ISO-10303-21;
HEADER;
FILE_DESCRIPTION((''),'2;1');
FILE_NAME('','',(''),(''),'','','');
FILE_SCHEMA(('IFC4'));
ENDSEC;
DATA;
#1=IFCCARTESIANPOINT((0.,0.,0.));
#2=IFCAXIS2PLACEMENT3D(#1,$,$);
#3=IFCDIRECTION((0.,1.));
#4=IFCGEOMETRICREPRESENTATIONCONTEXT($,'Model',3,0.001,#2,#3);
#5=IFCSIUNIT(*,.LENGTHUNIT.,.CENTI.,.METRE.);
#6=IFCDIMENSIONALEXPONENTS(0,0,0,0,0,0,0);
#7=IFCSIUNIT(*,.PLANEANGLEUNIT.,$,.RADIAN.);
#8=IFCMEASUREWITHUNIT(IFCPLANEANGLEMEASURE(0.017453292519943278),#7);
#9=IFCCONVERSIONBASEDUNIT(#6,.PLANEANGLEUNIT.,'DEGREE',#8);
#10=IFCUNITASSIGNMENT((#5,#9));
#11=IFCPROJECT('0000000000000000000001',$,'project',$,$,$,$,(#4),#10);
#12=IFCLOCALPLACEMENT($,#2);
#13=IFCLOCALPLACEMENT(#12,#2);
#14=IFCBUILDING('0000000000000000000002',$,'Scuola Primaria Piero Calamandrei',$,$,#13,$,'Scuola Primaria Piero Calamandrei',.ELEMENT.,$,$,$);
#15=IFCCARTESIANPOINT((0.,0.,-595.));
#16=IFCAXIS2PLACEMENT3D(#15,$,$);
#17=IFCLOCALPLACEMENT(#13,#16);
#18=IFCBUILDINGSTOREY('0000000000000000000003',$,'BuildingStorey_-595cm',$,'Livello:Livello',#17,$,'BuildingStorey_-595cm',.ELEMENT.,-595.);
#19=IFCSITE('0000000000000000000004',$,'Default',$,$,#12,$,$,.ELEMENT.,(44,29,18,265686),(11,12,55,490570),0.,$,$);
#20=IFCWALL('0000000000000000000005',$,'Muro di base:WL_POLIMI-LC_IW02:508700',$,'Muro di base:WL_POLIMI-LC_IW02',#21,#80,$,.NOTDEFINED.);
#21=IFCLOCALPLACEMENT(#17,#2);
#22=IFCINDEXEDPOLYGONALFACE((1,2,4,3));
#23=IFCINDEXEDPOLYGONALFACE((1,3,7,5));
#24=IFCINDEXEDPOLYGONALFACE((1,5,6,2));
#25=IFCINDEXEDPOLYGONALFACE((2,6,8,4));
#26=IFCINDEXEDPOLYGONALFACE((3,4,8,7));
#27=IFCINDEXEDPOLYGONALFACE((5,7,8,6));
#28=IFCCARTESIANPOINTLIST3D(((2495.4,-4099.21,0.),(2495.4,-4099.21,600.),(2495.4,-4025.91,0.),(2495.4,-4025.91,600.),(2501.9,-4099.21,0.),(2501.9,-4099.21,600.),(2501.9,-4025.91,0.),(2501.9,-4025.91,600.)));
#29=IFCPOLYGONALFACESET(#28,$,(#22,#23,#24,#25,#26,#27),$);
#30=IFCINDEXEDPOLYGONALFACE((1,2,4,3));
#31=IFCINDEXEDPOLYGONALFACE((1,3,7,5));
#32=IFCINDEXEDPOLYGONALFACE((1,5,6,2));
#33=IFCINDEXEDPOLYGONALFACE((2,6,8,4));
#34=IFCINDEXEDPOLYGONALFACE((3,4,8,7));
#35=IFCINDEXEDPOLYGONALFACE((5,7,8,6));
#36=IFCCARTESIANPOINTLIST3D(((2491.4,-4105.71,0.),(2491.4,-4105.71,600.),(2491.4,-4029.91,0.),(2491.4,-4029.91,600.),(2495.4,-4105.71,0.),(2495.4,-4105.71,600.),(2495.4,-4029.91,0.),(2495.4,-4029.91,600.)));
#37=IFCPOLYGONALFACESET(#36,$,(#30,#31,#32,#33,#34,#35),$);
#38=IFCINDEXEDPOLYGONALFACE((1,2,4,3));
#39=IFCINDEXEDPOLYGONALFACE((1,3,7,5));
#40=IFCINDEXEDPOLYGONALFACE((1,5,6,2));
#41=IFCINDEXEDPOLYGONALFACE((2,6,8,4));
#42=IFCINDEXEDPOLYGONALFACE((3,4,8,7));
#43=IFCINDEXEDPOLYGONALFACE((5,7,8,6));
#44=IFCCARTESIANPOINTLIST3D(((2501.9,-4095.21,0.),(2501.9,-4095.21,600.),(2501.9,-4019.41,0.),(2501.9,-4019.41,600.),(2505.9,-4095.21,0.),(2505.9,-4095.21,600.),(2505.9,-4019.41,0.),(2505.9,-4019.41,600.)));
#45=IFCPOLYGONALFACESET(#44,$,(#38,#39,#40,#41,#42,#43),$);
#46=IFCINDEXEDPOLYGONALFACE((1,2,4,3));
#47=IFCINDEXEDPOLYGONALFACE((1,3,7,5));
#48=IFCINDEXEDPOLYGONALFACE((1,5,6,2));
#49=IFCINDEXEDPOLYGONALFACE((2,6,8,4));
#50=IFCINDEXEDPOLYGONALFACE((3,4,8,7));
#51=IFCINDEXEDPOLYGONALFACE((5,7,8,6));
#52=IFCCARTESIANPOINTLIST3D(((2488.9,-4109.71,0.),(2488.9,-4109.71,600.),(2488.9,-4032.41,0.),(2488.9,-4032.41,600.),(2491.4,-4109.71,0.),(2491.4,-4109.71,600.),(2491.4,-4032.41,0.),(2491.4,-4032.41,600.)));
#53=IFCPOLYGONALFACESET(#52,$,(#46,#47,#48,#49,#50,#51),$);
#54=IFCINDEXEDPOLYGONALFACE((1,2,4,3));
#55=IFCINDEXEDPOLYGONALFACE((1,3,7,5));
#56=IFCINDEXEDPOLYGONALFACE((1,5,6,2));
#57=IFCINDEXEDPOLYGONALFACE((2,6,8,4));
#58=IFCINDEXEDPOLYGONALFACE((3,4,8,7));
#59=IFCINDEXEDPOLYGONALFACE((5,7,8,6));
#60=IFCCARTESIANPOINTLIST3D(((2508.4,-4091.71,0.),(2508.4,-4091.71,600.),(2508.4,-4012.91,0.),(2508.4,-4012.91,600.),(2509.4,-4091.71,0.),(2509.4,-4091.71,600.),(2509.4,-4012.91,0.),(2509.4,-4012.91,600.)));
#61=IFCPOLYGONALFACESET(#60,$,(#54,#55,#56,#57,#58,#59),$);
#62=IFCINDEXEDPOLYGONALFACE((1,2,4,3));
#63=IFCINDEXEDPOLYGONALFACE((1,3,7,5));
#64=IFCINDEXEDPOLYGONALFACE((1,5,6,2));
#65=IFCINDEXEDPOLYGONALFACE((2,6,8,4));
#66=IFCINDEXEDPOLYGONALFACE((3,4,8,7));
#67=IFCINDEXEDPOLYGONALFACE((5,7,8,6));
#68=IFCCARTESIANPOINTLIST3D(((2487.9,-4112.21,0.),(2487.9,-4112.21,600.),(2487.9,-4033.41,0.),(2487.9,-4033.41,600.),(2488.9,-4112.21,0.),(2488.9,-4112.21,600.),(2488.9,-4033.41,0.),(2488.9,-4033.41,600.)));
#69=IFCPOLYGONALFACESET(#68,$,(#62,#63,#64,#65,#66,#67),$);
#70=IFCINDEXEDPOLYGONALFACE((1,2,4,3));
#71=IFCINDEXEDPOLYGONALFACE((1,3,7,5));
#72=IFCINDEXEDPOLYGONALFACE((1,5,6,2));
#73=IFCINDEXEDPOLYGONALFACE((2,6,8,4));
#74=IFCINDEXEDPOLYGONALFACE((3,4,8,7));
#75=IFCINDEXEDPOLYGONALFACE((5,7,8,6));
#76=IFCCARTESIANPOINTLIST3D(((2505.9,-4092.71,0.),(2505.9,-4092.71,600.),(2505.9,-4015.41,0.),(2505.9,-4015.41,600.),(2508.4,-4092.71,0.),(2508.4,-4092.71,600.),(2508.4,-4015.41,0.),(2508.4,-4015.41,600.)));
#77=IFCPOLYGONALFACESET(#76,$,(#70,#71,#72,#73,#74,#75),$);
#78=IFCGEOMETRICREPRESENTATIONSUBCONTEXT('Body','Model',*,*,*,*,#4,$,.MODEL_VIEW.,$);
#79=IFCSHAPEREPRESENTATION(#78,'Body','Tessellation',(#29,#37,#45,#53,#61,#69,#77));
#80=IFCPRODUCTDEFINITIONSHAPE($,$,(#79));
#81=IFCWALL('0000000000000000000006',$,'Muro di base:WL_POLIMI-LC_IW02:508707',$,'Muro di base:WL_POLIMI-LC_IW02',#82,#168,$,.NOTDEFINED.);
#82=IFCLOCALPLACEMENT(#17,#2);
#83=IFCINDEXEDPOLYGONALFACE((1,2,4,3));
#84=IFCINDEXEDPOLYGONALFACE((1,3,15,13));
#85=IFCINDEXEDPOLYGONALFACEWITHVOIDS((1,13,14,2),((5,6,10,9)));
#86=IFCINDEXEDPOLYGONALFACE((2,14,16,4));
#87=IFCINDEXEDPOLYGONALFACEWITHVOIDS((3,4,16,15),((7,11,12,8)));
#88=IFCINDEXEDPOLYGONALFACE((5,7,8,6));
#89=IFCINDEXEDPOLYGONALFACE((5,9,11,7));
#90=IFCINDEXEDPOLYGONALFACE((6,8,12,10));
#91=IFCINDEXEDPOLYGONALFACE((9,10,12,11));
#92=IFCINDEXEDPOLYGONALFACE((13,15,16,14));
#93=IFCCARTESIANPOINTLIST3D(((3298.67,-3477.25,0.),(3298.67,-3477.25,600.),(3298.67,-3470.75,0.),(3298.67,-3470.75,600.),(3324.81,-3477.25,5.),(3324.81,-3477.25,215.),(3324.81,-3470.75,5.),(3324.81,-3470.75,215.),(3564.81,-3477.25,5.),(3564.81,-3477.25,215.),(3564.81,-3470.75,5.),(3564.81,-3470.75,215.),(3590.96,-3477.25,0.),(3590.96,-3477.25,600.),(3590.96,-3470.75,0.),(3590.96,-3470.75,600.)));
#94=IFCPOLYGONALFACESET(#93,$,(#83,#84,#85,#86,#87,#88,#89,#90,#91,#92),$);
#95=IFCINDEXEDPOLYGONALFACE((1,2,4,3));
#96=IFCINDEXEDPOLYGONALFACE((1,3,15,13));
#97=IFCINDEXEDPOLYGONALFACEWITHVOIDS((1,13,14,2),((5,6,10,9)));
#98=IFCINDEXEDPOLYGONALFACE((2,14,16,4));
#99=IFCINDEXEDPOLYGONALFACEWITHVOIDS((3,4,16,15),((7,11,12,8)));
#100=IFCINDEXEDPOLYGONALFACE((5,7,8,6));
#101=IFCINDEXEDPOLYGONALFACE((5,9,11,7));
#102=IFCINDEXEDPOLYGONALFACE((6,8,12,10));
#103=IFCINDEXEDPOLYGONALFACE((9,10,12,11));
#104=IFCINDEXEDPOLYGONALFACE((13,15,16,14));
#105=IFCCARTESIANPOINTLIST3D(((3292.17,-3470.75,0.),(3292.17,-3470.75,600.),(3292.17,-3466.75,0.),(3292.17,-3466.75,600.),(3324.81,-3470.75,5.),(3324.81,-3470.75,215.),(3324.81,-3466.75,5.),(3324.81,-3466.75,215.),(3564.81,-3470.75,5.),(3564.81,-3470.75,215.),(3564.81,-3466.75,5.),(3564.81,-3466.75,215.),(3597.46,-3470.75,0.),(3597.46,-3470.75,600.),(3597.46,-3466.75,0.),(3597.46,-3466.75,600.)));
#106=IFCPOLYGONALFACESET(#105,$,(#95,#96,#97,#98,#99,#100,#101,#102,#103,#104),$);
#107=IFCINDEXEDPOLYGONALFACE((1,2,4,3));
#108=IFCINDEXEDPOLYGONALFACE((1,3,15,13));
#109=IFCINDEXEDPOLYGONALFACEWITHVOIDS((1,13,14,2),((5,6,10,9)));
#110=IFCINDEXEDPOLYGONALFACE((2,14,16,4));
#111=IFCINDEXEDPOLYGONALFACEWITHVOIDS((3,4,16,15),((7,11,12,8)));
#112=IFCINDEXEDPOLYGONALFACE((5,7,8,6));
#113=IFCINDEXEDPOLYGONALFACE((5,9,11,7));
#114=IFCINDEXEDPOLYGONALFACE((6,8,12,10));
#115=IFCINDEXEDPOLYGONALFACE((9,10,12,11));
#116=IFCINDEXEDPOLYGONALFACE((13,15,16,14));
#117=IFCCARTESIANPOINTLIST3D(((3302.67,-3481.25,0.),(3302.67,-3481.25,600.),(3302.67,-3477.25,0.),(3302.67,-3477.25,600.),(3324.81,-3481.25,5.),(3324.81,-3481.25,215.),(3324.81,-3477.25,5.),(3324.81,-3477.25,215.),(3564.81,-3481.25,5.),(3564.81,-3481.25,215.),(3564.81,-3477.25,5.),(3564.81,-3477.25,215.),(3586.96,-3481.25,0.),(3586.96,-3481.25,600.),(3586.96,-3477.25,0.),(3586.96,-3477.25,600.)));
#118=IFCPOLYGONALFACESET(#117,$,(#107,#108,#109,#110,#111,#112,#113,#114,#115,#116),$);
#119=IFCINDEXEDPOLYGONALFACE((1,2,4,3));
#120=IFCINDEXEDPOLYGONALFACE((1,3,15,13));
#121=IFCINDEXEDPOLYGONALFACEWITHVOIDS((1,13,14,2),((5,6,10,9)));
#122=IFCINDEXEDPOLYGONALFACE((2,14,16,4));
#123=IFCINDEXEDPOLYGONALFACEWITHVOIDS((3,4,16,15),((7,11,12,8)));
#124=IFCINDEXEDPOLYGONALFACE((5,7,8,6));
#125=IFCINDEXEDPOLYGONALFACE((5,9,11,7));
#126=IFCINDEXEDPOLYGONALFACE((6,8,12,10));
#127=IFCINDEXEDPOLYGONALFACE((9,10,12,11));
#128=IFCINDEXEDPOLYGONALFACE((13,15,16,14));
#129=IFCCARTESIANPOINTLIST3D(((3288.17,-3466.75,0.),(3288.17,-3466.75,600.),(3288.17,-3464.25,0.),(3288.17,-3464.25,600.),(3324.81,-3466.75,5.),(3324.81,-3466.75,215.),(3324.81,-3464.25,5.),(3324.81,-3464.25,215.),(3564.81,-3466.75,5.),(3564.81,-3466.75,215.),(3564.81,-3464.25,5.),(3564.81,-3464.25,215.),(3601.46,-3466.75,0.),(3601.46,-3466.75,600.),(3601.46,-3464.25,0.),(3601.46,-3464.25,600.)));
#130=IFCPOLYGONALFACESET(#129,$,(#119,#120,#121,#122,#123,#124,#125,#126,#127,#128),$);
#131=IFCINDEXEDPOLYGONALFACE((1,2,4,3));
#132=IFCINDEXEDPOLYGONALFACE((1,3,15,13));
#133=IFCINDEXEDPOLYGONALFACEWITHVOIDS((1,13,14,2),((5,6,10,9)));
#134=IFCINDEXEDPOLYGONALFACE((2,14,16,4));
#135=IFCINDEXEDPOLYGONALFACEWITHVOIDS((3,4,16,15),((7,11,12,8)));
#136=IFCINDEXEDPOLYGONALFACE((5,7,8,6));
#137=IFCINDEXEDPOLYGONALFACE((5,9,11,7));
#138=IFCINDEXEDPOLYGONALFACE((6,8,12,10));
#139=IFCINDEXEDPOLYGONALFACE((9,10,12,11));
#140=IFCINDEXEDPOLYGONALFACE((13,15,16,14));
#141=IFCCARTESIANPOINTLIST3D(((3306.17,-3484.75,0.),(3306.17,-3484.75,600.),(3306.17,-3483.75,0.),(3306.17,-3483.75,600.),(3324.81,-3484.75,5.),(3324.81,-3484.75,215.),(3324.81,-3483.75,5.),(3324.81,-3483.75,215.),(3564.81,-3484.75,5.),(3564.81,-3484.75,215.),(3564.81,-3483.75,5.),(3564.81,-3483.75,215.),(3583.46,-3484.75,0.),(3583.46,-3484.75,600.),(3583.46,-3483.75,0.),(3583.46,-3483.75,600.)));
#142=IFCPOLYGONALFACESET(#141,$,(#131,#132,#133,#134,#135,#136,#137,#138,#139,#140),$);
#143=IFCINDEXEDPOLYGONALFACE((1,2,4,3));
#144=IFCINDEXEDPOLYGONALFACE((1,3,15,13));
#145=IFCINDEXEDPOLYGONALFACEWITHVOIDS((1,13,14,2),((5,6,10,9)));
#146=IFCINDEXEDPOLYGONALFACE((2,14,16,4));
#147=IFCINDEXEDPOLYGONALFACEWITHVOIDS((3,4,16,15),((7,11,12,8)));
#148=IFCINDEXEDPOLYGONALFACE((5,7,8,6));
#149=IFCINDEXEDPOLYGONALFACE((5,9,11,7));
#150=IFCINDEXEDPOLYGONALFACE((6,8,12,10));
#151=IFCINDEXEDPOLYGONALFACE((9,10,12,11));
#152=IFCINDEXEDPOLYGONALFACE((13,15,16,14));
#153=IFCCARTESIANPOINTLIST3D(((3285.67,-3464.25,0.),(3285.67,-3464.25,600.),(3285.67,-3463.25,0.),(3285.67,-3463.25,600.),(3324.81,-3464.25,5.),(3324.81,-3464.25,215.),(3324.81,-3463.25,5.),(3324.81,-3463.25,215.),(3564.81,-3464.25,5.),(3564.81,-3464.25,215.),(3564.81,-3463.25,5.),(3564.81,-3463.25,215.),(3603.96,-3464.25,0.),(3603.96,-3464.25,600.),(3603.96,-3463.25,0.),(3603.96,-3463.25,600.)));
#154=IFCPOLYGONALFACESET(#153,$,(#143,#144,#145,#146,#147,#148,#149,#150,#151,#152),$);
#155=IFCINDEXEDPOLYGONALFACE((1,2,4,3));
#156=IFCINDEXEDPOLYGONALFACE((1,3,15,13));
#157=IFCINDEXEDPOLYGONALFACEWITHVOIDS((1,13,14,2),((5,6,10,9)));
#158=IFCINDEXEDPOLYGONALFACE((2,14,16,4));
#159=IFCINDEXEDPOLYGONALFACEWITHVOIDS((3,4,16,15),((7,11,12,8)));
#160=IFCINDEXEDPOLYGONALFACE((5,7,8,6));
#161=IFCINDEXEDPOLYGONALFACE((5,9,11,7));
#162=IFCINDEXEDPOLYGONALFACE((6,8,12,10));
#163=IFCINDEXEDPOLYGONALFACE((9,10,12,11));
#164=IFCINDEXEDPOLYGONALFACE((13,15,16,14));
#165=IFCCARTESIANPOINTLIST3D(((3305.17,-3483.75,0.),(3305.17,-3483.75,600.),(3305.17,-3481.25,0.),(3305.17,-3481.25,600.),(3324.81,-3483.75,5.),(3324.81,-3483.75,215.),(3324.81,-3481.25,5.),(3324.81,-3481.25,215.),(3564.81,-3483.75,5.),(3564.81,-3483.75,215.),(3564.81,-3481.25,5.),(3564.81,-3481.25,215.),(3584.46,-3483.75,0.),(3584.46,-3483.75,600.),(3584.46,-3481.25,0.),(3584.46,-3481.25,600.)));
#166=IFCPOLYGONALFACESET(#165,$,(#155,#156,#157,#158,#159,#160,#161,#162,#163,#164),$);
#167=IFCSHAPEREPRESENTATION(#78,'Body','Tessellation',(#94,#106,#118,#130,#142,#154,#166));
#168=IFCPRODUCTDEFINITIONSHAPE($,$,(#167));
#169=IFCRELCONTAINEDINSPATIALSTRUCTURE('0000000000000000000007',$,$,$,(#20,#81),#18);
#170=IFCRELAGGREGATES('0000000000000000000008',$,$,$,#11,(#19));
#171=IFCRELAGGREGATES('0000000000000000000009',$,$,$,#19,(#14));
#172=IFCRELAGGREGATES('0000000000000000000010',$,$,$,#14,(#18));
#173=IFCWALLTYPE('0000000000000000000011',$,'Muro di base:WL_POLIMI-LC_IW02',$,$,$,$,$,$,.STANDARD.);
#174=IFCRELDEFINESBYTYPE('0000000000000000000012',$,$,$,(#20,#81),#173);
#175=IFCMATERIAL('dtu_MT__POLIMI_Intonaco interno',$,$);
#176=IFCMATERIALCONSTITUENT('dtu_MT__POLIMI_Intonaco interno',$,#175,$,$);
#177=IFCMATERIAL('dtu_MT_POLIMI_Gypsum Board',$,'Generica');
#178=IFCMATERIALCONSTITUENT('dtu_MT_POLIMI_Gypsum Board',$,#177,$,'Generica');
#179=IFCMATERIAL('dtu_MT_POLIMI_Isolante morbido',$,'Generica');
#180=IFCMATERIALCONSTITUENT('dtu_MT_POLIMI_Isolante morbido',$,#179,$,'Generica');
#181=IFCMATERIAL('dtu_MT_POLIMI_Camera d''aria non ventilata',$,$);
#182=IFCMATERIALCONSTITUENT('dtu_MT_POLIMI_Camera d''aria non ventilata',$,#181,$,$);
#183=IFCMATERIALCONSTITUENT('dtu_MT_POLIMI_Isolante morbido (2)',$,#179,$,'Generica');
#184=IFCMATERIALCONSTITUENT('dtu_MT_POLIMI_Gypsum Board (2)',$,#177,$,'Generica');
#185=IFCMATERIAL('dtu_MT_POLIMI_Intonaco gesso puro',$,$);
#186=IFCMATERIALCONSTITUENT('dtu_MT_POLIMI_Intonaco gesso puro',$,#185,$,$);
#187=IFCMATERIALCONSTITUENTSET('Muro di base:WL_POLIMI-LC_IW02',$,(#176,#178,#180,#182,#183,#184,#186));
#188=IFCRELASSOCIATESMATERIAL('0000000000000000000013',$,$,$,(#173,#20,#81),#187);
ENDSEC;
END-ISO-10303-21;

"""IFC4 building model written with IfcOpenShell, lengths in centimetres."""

from ifc_helpers import new_model, entity, si_unit, converted_unit, direction, frame, origin, place, context, subcontext, project, spatial, indexed_curve, outline, extrude, material, constituent, constituent_set, type_object, element, save


model = new_model("IFC4")

# Units and contexts
model_context = context("Model", 3, precision=0.001, world=origin(), true_north=direction((0.0, 1.0)))
body_context = subcontext(model_context, "Body", "Model", "MODEL_VIEW")
ifc_project = project(units=[si_unit("LENGTHUNIT", "METRE", prefix="CENTI"), converted_unit("PLANEANGLEUNIT", "DEGREE", entity("IfcPlaneAngleMeasure", 0.017453292519943278), si_unit("PLANEANGLEUNIT", "RADIAN"), dimensions=[0, 0, 0, 0, 0, 0, 0])], contexts=[model_context])

# Site, building, storey
site_placement = place(None, origin())
site = spatial("IfcSite", under=ifc_project, at=site_placement, Name="Default", CompositionType="ELEMENT", RefLatitude=(44, 29, 18, 265686), RefLongitude=(11, 12, 55, 490570), RefElevation=0.0)
building_placement = place(site_placement, origin())
building = spatial("IfcBuilding", under=site, at=building_placement, Name="Scuola Primaria Piero Calamandrei", LongName="Scuola Primaria Piero Calamandrei", CompositionType="ELEMENT")
storey_placement = place(building_placement, frame((0.0, 0.0, -595.0)))
storey = spatial("IfcBuildingStorey", under=building, at=storey_placement, Name="BuildingStorey_-595cm", ObjectType="Livello:Livello", LongName="BuildingStorey_-595cm", CompositionType="ELEMENT", Elevation=-595.0)

# Shared definitions
ifc_material_1 = material(Name="dtu_MT__POLIMI_Intonaco interno")
ifc_constituent_1 = constituent(ifc_material_1, Name="dtu_MT__POLIMI_Intonaco interno")
ifc_material_2 = material(Name="dtu_MT_POLIMI_Gypsum Board", Category="Generica")
ifc_constituent_2 = constituent(ifc_material_2, Name="dtu_MT_POLIMI_Gypsum Board", Category="Generica")
ifc_material_3 = material(Name="dtu_MT_POLIMI_Isolante morbido", Category="Generica")
ifc_constituent_3 = constituent(ifc_material_3, Name="dtu_MT_POLIMI_Isolante morbido", Category="Generica")
ifc_material_4 = material(Name="dtu_MT_POLIMI_Camera d'aria non ventilata")
ifc_constituent_4 = constituent(ifc_material_4, Name="dtu_MT_POLIMI_Camera d'aria non ventilata")
ifc_constituent_5 = constituent(ifc_material_3, Name="dtu_MT_POLIMI_Isolante morbido (2)", Category="Generica")
ifc_constituent_6 = constituent(ifc_material_2, Name="dtu_MT_POLIMI_Gypsum Board (2)", Category="Generica")
ifc_material_5 = material(Name="dtu_MT_POLIMI_Intonaco gesso puro")
ifc_constituent_7 = constituent(ifc_material_5, Name="dtu_MT_POLIMI_Intonaco gesso puro")
ifc_constituent_set_1 = constituent_set(constituents=[ifc_constituent_1, ifc_constituent_2, ifc_constituent_3, ifc_constituent_4, ifc_constituent_5, ifc_constituent_6, ifc_constituent_7], Name="Muro di base:WL_POLIMI-LC_IW02")
wall_type_1 = type_object("IfcWallType", Name="Muro di base:WL_POLIMI-LC_IW02", PredefinedType="STANDARD", material=ifc_constituent_set_1)

# Wall
wall_1_placement = place(storey_placement, frame((2498.65, -4091.71, 0.0), z_axis=(0.0, 0.0, 1.0), x_axis=(0.0, 1.0, 0.0)))
element("IfcWall", 1, at=wall_1_placement, inside=storey, type_object=wall_type_1, material=ifc_constituent_set_1, Name="Muro di base:WL_POLIMI-LC_IW02:508700", ObjectType="Muro di base:WL_POLIMI-LC_IW02", PredefinedType="NOTDEFINED", context=body_context, shape_type="SweptSolid", body=[
    extrude(outline(indexed_curve([(-36.65, -3.25), (36.65, -3.25), (36.65, 3.25), (-36.65, 3.25), (-36.65, -3.25)], self_intersect=False)), frame((29.15, 0.0, 0.0)), (0.0, 0.0, 1.0), 600.0),
    extrude(outline(indexed_curve([(-37.9, -2.0), (37.9, -2.0), (37.9, 2.0), (-37.9, 2.0), (-37.9, -2.0)], self_intersect=False)), frame((23.9, 5.25, 0.0)), (0.0, 0.0, 1.0), 600.0),
    extrude(outline(indexed_curve([(-37.9, -2.0), (37.9, -2.0), (37.9, 2.0), (-37.9, 2.0), (-37.9, -2.0)], self_intersect=False)), frame((34.4, -5.25, 0.0)), (0.0, 0.0, 1.0), 600.0),
    extrude(outline(indexed_curve([(-38.65, -1.25), (38.65, -1.25), (38.65, 1.25), (-38.65, 1.25), (-38.65, -1.25)], self_intersect=False)), frame((20.65, 8.5, 0.0)), (0.0, 0.0, 1.0), 600.0),
    extrude(outline(indexed_curve([(-0.5, -39.4), (0.5, -39.4), (0.5, 39.4), (-0.5, 39.4), (-0.5, -39.4)], self_intersect=False)), frame((39.4, -10.25, 0.0), z_axis=(0.0, 0.0, 1.0), x_axis=(0.0, 1.0, 0.0)), (0.0, 0.0, 1.0), 600.0),
    extrude(outline(indexed_curve([(-0.5, -39.4), (0.5, -39.4), (0.5, 39.4), (-0.5, 39.4), (-0.5, -39.4)], self_intersect=False)), frame((18.9, 10.25, 0.0), z_axis=(0.0, 0.0, 1.0), x_axis=(0.0, -1.0, 0.0)), (0.0, 0.0, 1.0), 600.0),
    extrude(outline(indexed_curve([(-38.65, -1.25), (38.65, -1.25), (38.65, 1.25), (-38.65, 1.25), (-38.65, -1.25)], self_intersect=False)), frame((37.65, -8.5, 0.0)), (0.0, 0.0, 1.0), 600.0),
])

# Wall, opening
wall_2_placement = place(storey_placement, frame((3306.17, -3474.0, 0.0)))
wall_2 = element("IfcWall", 2, at=wall_2_placement, inside=storey, type_object=wall_type_1, material=ifc_constituent_set_1, Name="Muro di base:WL_POLIMI-LC_IW02:508707", ObjectType="Muro di base:WL_POLIMI-LC_IW02", PredefinedType="NOTDEFINED", context=body_context, shape_type="SweptSolid", body=[
    extrude(outline(indexed_curve([(-300.0, -146.14), (300.0, -146.14), (300.0, 146.14), (-300.0, 146.14), (-300.0, -146.14)], self_intersect=False), holes=[indexed_curve([(-295.0, -120.0), (-295.0, 120.0), (-85.0, 120.0), (-85.0, -120.0), (-295.0, -120.0)], self_intersect=False)]), frame((138.64, -3.25, 300.0), z_axis=(0.0, 1.0, 0.0), x_axis=(0.0, 0.0, 1.0)), (0.0, 0.0, 1.0), 6.5),
    extrude(outline(indexed_curve([(-300.0, -152.64), (300.0, -152.64), (300.0, 152.64), (-300.0, 152.64), (-300.0, -152.64)], self_intersect=False), holes=[indexed_curve([(-295.0, -120.0), (-295.0, 120.0), (-85.0, 120.0), (-85.0, -120.0), (-295.0, -120.0)], self_intersect=False)]), frame((138.64, 3.25, 300.0), z_axis=(0.0, 1.0, 0.0), x_axis=(0.0, 0.0, 1.0)), (0.0, 0.0, 1.0), 4.0),
    extrude(outline(indexed_curve([(-300.0, -142.14), (300.0, -142.14), (300.0, 142.14), (-300.0, 142.14), (-300.0, -142.14)], self_intersect=False), holes=[indexed_curve([(-295.0, -120.0), (-295.0, 120.0), (-85.0, 120.0), (-85.0, -120.0), (-295.0, -120.0)], self_intersect=False)]), frame((138.64, -7.25, 300.0), z_axis=(0.0, 1.0, 0.0), x_axis=(0.0, 0.0, 1.0)), (0.0, 0.0, 1.0), 4.0),
    extrude(outline(indexed_curve([(-300.0, -156.64), (300.0, -156.64), (300.0, 156.64), (-300.0, 156.64), (-300.0, -156.64)], self_intersect=False), holes=[indexed_curve([(-295.0, -120.0), (-295.0, 120.0), (-85.0, 120.0), (-85.0, -120.0), (-295.0, -120.0)], self_intersect=False)]), frame((138.64, 7.25, 300.0), z_axis=(0.0, 1.0, 0.0), x_axis=(0.0, 0.0, 1.0)), (0.0, 0.0, 1.0), 2.5),
    extrude(outline(indexed_curve([(-300.0, -138.64), (300.0, -138.64), (300.0, 138.64), (-300.0, 138.64), (-300.0, -138.64)], self_intersect=False), holes=[indexed_curve([(-85.0, -120.0), (-295.0, -120.0), (-295.0, 120.0), (-85.0, 120.0), (-85.0, -120.0)], self_intersect=False)]), frame((138.64, -10.75, 300.0), z_axis=(0.0, 1.0, 0.0), x_axis=(0.0, 0.0, 1.0)), (0.0, 0.0, 1.0), 1.0),
    extrude(outline(indexed_curve([(-300.0, -159.14), (300.0, -159.14), (300.0, 159.14), (-300.0, 159.14), (-300.0, -159.14)], self_intersect=False), holes=[indexed_curve([(-295.0, -120.0), (-295.0, 120.0), (-85.0, 120.0), (-85.0, -120.0), (-295.0, -120.0)], self_intersect=False)]), frame((138.64, 9.75, 300.0), z_axis=(0.0, 1.0, 0.0), x_axis=(0.0, 0.0, 1.0)), (0.0, 0.0, 1.0), 1.0),
    extrude(outline(indexed_curve([(-300.0, -139.64), (300.0, -139.64), (300.0, 139.64), (-300.0, 139.64), (-300.0, -139.64)], self_intersect=False), holes=[indexed_curve([(-295.0, -120.0), (-295.0, 120.0), (-85.0, 120.0), (-85.0, -120.0), (-295.0, -120.0)], self_intersect=False)]), frame((138.64, -9.75, 300.0), z_axis=(0.0, 1.0, 0.0), x_axis=(0.0, 0.0, 1.0)), (0.0, 0.0, 1.0), 2.5),
])
opening_1_placement = place(wall_2_placement, frame((258.64, 10.75, 5.0)))
element("IfcOpeningElement", 3, at=opening_1_placement, cuts=wall_2, PredefinedType="OPENING", context=body_context, shape_type="SweptSolid", body=[
    extrude(outline(indexed_curve([(210.0, 240.0), (0.0, 240.0), (0.0, 0.0), (210.0, 0.0), (210.0, 240.0)], self_intersect=False)), frame((0.0, 0.0, 0.0), z_axis=(0.0, -1.0, 0.0), x_axis=(0.0, 0.0, 1.0)), (0.0, 0.0, 1.0), 21.5),
])

save(model, "model.ifc")
